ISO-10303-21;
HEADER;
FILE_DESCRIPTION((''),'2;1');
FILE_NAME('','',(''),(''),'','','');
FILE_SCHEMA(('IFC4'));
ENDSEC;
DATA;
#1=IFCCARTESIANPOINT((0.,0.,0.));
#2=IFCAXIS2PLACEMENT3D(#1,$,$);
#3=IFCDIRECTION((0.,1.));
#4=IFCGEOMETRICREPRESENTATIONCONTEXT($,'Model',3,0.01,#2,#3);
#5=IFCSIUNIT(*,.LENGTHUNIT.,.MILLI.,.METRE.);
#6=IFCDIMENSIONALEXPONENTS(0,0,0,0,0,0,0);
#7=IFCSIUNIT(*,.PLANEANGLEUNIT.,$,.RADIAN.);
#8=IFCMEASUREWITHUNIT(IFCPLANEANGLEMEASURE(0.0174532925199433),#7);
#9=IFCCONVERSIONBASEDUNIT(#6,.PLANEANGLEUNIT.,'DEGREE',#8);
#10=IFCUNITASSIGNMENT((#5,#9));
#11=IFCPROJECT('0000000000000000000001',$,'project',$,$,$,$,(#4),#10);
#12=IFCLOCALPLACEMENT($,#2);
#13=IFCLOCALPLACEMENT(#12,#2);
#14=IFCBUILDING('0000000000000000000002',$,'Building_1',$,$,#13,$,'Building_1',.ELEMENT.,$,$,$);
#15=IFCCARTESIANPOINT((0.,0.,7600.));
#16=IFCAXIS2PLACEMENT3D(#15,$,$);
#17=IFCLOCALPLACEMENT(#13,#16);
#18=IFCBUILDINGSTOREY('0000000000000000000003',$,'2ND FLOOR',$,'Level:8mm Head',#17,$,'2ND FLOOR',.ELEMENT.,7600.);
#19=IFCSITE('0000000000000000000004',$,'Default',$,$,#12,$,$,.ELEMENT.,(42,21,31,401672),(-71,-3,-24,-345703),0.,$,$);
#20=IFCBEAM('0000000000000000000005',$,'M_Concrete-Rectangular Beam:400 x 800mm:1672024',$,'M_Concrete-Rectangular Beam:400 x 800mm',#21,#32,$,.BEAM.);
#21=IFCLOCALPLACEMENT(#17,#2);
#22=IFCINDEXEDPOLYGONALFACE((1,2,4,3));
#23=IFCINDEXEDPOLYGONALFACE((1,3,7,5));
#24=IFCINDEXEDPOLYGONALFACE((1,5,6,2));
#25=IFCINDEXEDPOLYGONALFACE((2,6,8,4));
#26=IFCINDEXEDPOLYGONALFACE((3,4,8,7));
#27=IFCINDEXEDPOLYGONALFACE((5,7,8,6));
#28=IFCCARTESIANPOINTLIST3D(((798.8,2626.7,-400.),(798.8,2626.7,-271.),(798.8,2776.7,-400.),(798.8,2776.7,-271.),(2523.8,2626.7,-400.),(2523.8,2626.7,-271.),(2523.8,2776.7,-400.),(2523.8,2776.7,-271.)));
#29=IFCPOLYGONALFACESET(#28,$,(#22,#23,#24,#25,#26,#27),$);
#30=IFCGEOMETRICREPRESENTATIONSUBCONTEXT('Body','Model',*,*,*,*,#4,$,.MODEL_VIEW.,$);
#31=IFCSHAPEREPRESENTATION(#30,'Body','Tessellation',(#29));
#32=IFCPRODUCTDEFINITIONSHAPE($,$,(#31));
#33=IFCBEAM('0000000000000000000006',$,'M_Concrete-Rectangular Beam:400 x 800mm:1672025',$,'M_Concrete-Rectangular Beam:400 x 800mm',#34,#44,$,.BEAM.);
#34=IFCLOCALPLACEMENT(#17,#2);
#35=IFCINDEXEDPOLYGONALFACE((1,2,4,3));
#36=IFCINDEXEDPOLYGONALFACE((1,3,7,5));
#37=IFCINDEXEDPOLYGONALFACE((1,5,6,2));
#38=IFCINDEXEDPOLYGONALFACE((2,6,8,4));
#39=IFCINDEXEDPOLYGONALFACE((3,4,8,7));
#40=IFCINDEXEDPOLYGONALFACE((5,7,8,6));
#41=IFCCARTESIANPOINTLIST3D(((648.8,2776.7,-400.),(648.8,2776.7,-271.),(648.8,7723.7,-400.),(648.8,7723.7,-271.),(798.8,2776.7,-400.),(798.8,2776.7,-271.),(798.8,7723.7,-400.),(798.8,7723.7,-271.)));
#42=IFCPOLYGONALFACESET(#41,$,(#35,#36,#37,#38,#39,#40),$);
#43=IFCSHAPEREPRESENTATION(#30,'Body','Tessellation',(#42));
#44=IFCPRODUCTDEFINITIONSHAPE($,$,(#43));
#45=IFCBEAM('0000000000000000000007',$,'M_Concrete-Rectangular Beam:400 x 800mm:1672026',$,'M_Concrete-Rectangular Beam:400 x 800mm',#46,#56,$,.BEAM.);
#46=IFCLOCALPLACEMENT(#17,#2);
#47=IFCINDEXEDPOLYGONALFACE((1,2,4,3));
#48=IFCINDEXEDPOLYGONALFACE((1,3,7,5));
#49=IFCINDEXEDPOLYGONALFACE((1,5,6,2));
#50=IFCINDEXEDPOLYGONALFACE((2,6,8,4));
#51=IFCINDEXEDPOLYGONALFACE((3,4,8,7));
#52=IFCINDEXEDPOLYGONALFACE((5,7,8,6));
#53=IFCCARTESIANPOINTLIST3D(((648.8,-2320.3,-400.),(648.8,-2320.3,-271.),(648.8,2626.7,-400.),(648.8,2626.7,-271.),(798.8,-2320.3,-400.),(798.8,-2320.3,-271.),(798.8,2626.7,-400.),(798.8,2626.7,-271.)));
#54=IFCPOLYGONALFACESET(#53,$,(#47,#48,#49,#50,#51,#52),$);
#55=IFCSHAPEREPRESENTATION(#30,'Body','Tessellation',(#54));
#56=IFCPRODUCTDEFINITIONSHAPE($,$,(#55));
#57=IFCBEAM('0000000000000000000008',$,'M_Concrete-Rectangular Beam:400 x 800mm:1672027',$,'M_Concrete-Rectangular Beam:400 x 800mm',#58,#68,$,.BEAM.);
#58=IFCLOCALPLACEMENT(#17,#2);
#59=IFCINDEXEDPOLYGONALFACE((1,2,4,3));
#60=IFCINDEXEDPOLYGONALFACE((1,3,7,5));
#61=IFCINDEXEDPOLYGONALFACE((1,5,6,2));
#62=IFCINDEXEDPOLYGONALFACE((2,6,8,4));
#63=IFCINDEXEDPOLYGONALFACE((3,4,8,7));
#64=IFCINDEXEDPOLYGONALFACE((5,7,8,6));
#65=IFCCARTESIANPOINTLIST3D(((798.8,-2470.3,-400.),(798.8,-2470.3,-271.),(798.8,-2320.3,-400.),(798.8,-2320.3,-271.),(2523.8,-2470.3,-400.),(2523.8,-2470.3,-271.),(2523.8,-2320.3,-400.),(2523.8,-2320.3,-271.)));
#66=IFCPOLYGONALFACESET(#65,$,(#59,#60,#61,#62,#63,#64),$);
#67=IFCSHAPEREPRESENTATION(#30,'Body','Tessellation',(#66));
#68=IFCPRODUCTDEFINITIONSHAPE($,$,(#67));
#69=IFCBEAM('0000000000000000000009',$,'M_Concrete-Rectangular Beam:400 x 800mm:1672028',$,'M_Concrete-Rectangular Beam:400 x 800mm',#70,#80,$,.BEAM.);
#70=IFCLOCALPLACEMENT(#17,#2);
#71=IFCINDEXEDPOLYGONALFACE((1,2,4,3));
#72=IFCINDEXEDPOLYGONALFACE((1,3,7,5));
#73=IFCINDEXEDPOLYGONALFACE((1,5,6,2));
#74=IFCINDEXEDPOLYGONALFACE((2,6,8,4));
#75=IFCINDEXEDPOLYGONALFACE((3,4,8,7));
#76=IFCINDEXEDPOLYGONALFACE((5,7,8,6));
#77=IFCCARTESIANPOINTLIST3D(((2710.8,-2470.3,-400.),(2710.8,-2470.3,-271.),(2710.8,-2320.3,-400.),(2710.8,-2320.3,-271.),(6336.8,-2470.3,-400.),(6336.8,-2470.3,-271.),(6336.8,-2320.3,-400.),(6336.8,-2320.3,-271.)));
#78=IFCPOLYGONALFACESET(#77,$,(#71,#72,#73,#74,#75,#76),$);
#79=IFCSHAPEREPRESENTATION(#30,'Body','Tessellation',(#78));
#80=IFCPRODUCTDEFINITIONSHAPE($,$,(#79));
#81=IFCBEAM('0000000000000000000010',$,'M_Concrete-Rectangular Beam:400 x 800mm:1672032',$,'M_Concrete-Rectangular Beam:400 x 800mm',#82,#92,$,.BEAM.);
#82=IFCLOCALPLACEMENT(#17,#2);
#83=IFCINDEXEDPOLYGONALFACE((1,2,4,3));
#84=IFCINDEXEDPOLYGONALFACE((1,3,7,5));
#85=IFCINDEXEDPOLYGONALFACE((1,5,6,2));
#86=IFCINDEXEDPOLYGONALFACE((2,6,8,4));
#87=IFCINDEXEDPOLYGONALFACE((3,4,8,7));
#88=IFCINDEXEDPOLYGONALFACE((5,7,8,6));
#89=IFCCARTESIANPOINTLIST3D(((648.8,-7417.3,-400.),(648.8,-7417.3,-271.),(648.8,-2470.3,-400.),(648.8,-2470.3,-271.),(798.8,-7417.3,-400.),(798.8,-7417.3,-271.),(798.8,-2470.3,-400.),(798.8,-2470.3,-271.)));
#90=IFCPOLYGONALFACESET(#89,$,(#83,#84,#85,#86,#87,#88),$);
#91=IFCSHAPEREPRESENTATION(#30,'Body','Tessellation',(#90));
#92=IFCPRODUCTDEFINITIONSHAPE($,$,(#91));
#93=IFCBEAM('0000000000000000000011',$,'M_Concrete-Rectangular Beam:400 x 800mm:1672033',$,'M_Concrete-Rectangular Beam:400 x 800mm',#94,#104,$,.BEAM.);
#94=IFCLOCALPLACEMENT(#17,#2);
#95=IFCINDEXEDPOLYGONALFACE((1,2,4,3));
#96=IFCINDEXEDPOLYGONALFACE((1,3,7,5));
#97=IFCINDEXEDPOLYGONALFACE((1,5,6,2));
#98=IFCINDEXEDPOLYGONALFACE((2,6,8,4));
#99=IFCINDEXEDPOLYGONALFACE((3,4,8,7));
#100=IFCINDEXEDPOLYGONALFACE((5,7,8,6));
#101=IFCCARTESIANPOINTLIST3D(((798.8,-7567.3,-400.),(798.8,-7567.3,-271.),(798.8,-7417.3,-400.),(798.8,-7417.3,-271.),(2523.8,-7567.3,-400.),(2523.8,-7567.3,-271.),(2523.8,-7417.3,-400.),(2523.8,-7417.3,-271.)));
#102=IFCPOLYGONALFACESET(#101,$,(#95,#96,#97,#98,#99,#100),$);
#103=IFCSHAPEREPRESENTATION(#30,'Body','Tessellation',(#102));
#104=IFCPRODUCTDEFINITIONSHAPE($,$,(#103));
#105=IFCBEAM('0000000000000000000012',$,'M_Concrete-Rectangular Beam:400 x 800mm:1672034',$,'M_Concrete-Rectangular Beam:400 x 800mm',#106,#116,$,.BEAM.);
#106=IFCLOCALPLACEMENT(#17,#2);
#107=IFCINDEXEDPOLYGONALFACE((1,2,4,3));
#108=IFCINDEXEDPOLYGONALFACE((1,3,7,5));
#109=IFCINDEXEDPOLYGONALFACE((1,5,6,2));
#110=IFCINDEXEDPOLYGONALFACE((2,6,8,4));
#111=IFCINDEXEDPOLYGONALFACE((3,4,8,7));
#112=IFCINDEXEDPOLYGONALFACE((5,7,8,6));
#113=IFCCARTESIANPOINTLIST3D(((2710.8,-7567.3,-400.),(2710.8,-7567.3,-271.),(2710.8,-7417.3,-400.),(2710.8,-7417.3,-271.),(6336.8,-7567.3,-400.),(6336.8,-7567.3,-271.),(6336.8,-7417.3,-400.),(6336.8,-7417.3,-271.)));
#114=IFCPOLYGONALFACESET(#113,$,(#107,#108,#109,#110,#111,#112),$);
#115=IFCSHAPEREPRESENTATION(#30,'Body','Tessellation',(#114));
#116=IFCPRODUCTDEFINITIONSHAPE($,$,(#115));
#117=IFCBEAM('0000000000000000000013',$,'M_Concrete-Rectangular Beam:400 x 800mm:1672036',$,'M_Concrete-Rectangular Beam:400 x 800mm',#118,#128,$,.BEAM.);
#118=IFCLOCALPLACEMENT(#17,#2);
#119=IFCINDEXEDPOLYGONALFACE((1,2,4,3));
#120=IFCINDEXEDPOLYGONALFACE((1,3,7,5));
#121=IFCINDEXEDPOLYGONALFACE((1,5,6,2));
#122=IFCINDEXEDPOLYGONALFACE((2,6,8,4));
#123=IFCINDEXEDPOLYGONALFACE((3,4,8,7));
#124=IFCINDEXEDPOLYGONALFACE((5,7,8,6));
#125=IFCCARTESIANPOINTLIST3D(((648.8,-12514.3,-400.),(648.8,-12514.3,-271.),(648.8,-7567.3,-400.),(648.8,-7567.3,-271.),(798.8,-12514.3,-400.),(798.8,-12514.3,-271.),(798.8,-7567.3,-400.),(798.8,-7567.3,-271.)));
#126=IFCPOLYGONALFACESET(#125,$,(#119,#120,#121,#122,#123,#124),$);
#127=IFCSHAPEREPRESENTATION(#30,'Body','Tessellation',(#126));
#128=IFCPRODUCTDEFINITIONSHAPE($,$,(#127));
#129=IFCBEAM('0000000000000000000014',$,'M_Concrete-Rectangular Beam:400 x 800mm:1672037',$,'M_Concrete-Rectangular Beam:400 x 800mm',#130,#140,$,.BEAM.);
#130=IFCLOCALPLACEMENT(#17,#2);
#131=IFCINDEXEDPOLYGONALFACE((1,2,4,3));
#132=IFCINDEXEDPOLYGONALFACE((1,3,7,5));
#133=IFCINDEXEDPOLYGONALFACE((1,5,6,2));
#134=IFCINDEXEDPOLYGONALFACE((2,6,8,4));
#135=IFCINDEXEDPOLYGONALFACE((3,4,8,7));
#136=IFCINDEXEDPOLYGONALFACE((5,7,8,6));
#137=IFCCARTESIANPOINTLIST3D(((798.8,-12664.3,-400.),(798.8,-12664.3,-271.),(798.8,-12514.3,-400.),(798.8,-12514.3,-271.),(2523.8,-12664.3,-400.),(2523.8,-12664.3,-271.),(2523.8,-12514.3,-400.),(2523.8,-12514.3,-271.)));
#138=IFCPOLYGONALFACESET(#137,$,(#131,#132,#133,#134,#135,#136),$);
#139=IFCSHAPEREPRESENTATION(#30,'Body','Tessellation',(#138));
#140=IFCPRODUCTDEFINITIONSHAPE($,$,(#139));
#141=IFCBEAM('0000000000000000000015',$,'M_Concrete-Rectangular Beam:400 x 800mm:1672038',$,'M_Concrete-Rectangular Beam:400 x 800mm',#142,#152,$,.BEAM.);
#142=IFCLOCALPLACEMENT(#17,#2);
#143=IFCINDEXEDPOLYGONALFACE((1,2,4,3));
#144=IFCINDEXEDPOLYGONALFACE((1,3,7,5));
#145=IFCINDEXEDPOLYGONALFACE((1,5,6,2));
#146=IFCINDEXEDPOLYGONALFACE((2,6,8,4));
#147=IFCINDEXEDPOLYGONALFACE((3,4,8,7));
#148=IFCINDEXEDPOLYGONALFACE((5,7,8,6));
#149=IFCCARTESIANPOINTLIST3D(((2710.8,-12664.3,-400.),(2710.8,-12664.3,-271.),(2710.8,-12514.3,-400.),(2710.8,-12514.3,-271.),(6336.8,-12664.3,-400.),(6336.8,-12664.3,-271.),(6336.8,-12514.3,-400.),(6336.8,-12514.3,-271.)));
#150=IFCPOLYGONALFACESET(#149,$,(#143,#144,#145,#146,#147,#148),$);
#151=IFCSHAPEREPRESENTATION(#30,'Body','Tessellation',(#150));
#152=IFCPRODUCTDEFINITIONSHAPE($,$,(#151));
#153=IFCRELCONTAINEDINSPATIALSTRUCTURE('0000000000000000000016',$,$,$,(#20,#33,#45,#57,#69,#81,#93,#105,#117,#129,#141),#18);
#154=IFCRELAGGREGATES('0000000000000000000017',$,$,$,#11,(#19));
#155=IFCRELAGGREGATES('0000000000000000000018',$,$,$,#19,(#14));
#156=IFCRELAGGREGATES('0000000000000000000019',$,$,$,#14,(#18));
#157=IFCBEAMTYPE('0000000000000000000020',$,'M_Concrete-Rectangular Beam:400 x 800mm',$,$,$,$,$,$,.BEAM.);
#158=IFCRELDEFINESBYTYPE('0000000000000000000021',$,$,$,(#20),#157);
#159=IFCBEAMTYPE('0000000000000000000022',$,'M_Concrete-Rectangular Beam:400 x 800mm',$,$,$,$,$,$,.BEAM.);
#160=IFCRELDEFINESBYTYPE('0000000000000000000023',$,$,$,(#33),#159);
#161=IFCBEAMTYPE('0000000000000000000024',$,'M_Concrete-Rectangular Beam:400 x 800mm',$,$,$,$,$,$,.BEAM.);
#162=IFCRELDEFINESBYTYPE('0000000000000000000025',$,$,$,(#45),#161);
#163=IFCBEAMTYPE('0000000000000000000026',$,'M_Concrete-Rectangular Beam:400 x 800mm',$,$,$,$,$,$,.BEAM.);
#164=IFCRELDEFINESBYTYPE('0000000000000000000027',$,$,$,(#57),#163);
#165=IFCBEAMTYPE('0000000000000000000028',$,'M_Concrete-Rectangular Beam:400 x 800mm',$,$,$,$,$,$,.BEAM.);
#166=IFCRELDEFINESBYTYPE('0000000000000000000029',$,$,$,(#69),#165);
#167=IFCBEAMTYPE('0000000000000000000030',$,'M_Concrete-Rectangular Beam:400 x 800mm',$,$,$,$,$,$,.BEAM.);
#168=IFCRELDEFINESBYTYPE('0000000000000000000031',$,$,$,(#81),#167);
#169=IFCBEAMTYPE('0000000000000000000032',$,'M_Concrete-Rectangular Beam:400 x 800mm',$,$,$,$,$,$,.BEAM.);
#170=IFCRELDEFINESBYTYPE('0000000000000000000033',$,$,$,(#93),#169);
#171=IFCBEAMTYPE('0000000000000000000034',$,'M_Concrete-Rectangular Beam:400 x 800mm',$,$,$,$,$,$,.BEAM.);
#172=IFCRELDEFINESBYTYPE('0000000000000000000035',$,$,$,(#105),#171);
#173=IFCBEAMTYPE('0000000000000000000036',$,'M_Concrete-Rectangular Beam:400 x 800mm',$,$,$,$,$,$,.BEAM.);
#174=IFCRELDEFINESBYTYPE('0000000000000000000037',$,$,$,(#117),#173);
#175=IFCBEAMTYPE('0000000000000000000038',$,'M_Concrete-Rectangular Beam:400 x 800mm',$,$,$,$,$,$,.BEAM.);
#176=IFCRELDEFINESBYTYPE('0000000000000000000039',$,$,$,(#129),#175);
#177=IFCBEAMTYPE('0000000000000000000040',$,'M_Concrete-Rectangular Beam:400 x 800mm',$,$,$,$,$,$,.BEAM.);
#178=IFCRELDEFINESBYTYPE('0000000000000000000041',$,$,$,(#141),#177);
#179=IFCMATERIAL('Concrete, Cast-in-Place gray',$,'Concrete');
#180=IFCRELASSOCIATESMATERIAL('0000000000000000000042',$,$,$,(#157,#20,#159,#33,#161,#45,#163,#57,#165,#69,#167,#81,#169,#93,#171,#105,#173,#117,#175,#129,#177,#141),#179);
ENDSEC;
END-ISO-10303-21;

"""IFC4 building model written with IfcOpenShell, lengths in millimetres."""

from ifc_helpers import new_model, entity, si_unit, converted_unit, direction, frame, origin, place, context, subcontext, project, spatial, indexed_curve, outline, extrude, source, transform, mapped, material, type_object, type_shapes, element, save


model = new_model("IFC4")

# Units and contexts
model_context = context("Model", 3, precision=0.01, world=origin(), true_north=direction((0.0, 1.0)))
body_context = subcontext(model_context, "Body", "Model", "MODEL_VIEW")
ifc_project = project(units=[si_unit("LENGTHUNIT", "METRE", prefix="MILLI"), converted_unit("PLANEANGLEUNIT", "DEGREE", entity("IfcPlaneAngleMeasure", 0.0174532925199433), si_unit("PLANEANGLEUNIT", "RADIAN"), dimensions=[0, 0, 0, 0, 0, 0, 0])], contexts=[model_context])

# Site, building, storey
site_placement = place(None, origin())
site = spatial("IfcSite", under=ifc_project, at=site_placement, Name="Default", CompositionType="ELEMENT", RefLatitude=(42, 21, 31, 401672), RefLongitude=(-71, -3, -24, -345703), RefElevation=0.0)
building_placement = place(site_placement, origin())
building = spatial("IfcBuilding", under=site, at=building_placement, Name="Building_1", LongName="Building_1", CompositionType="ELEMENT")
storey_placement = place(building_placement, frame((0.0, 0.0, 7600.0)))
storey = spatial("IfcBuildingStorey", under=building, at=storey_placement, Name="2ND FLOOR", ObjectType="Level:8mm Head", LongName="2ND FLOOR", CompositionType="ELEMENT", Elevation=7600.0)

# Shared definitions
ifc_material_1 = material(Name="Concrete, Cast-in-Place gray", Category="Concrete")

# Beams
beam_type_1 = type_object("IfcBeamType", Name="M_Concrete-Rectangular Beam:400 x 800mm", PredefinedType="BEAM", material=ifc_material_1)
shared_shape_1 = source(origin(), body_context, "Body", "SweptSolid", [
    extrude(outline(indexed_curve([(-64.5, -75.0), (64.5, -75.0), (64.5, 75.0), (-64.5, 75.0), (-64.5, -75.0)], self_intersect=False)), frame((2523.8, 2701.7, 7264.5), z_axis=(-1.0, 0.0, 0.0), x_axis=(0.0, 0.0, -1.0)), (0.0, 0.0, 1.0), 1725.0),
])
type_shapes(beam_type_1, [shared_shape_1])
beam_1_placement = place(storey_placement, frame((0.0, 0.0, -7600.0)))
element("IfcBeam", 1, at=beam_1_placement, inside=storey, type_object=beam_type_1, material=ifc_material_1, Name="M_Concrete-Rectangular Beam:400 x 800mm:1672024", ObjectType="M_Concrete-Rectangular Beam:400 x 800mm", PredefinedType="BEAM", context=body_context, shape_type="MappedRepresentation", body=[
    mapped(shared_shape_1, transform((0.0, 0.0, 0.0), scale=1.0)),
])
beam_type_2 = type_object("IfcBeamType", Name="M_Concrete-Rectangular Beam:400 x 800mm", PredefinedType="BEAM", material=ifc_material_1)
shared_shape_2 = source(origin(), body_context, "Body", "SweptSolid", [
    extrude(outline(indexed_curve([(-75.0, -64.5), (75.0, -64.5), (75.0, 64.5), (-75.0, 64.5), (-75.0, -64.5)], self_intersect=False)), frame((723.8, 2776.7, 7264.5), z_axis=(0.0, 1.0, 0.0), x_axis=(-1.0, 0.0, 0.0)), (0.0, 0.0, 1.0), 4947.0),
])
type_shapes(beam_type_2, [shared_shape_2])
beam_2_placement = place(storey_placement, frame((0.0, 0.0, -7600.0)))
element("IfcBeam", 2, at=beam_2_placement, inside=storey, type_object=beam_type_2, material=ifc_material_1, Name="M_Concrete-Rectangular Beam:400 x 800mm:1672025", ObjectType="M_Concrete-Rectangular Beam:400 x 800mm", PredefinedType="BEAM", context=body_context, shape_type="MappedRepresentation", body=[
    mapped(shared_shape_2, transform((0.0, 0.0, 0.0), scale=1.0)),
])
beam_type_3 = type_object("IfcBeamType", Name="M_Concrete-Rectangular Beam:400 x 800mm", PredefinedType="BEAM", material=ifc_material_1)
shared_shape_3 = source(origin(), body_context, "Body", "SweptSolid", [
    extrude(outline(indexed_curve([(-75.0, -64.5), (75.0, -64.5), (75.0, 64.5), (-75.0, 64.5), (-75.0, -64.5)], self_intersect=False)), frame((723.8, 2626.7, 7264.5), z_axis=(0.0, -1.0, 0.0), x_axis=(-1.0, 0.0, 0.0)), (0.0, 0.0, 1.0), 4947.0),
])
type_shapes(beam_type_3, [shared_shape_3])
beam_3_placement = place(storey_placement, frame((0.0, 0.0, -7600.0)))
element("IfcBeam", 3, at=beam_3_placement, inside=storey, type_object=beam_type_3, material=ifc_material_1, Name="M_Concrete-Rectangular Beam:400 x 800mm:1672026", ObjectType="M_Concrete-Rectangular Beam:400 x 800mm", PredefinedType="BEAM", context=body_context, shape_type="MappedRepresentation", body=[
    mapped(shared_shape_3, transform((0.0, 0.0, 0.0), scale=1.0)),
])
beam_type_4 = type_object("IfcBeamType", Name="M_Concrete-Rectangular Beam:400 x 800mm", PredefinedType="BEAM", material=ifc_material_1)
shared_shape_4 = source(origin(), body_context, "Body", "SweptSolid", [
    extrude(outline(indexed_curve([(-64.5, -75.0), (64.5, -75.0), (64.5, 75.0), (-64.5, 75.0), (-64.5, -75.0)], self_intersect=False)), frame((798.8, -2395.3, 7264.5), z_axis=(1.0, 0.0, 0.0), x_axis=(0.0, 0.0, -1.0)), (0.0, 0.0, 1.0), 1725.0),
])
type_shapes(beam_type_4, [shared_shape_4])
beam_4_placement = place(storey_placement, frame((0.0, 0.0, -7600.0)))
element("IfcBeam", 4, at=beam_4_placement, inside=storey, type_object=beam_type_4, material=ifc_material_1, Name="M_Concrete-Rectangular Beam:400 x 800mm:1672027", ObjectType="M_Concrete-Rectangular Beam:400 x 800mm", PredefinedType="BEAM", context=body_context, shape_type="MappedRepresentation", body=[
    mapped(shared_shape_4, transform((0.0, 0.0, 0.0), scale=1.0)),
])
beam_type_5 = type_object("IfcBeamType", Name="M_Concrete-Rectangular Beam:400 x 800mm", PredefinedType="BEAM", material=ifc_material_1)
shared_shape_5 = source(origin(), body_context, "Body", "SweptSolid", [
    extrude(outline(indexed_curve([(-64.5, -75.0), (64.5, -75.0), (64.5, 75.0), (-64.5, 75.0), (-64.5, -75.0)], self_intersect=False)), frame((2710.8, -2395.3, 7264.5), z_axis=(1.0, 0.0, 0.0), x_axis=(0.0, 0.0, -1.0)), (0.0, 0.0, 1.0), 3626.0),
])
type_shapes(beam_type_5, [shared_shape_5])
beam_5_placement = place(storey_placement, frame((0.0, 0.0, -7600.0)))
element("IfcBeam", 5, at=beam_5_placement, inside=storey, type_object=beam_type_5, material=ifc_material_1, Name="M_Concrete-Rectangular Beam:400 x 800mm:1672028", ObjectType="M_Concrete-Rectangular Beam:400 x 800mm", PredefinedType="BEAM", context=body_context, shape_type="MappedRepresentation", body=[
    mapped(shared_shape_5, transform((0.0, 0.0, 0.0), scale=1.0)),
])
beam_type_6 = type_object("IfcBeamType", Name="M_Concrete-Rectangular Beam:400 x 800mm", PredefinedType="BEAM", material=ifc_material_1)
shared_shape_6 = source(origin(), body_context, "Body", "SweptSolid", [
    extrude(outline(indexed_curve([(-75.0, -64.5), (75.0, -64.5), (75.0, 64.5), (-75.0, 64.5), (-75.0, -64.5)], self_intersect=False)), frame((723.8, -2470.3, 7264.5), z_axis=(0.0, -1.0, 0.0), x_axis=(-1.0, 0.0, 0.0)), (0.0, 0.0, 1.0), 4947.0),
])
type_shapes(beam_type_6, [shared_shape_6])
beam_6_placement = place(storey_placement, frame((0.0, 0.0, -7600.0)))
element("IfcBeam", 6, at=beam_6_placement, inside=storey, type_object=beam_type_6, material=ifc_material_1, Name="M_Concrete-Rectangular Beam:400 x 800mm:1672032", ObjectType="M_Concrete-Rectangular Beam:400 x 800mm", PredefinedType="BEAM", context=body_context, shape_type="MappedRepresentation", body=[
    mapped(shared_shape_6, transform((0.0, 0.0, 0.0), scale=1.0)),
])
beam_type_7 = type_object("IfcBeamType", Name="M_Concrete-Rectangular Beam:400 x 800mm", PredefinedType="BEAM", material=ifc_material_1)
shared_shape_7 = source(origin(), body_context, "Body", "SweptSolid", [
    extrude(outline(indexed_curve([(-64.5, -75.0), (64.5, -75.0), (64.5, 75.0), (-64.5, 75.0), (-64.5, -75.0)], self_intersect=False)), frame((798.8, -7492.3, 7264.5), z_axis=(1.0, 0.0, 0.0), x_axis=(0.0, 0.0, -1.0)), (0.0, 0.0, 1.0), 1725.0),
])
type_shapes(beam_type_7, [shared_shape_7])
beam_7_placement = place(storey_placement, frame((0.0, 0.0, -7600.0)))
element("IfcBeam", 7, at=beam_7_placement, inside=storey, type_object=beam_type_7, material=ifc_material_1, Name="M_Concrete-Rectangular Beam:400 x 800mm:1672033", ObjectType="M_Concrete-Rectangular Beam:400 x 800mm", PredefinedType="BEAM", context=body_context, shape_type="MappedRepresentation", body=[
    mapped(shared_shape_7, transform((0.0, 0.0, 0.0), scale=1.0)),
])
beam_type_8 = type_object("IfcBeamType", Name="M_Concrete-Rectangular Beam:400 x 800mm", PredefinedType="BEAM", material=ifc_material_1)
shared_shape_8 = source(origin(), body_context, "Body", "SweptSolid", [
    extrude(outline(indexed_curve([(-64.5, -75.0), (64.5, -75.0), (64.5, 75.0), (-64.5, 75.0), (-64.5, -75.0)], self_intersect=False)), frame((2710.8, -7492.3, 7264.5), z_axis=(1.0, 0.0, 0.0), x_axis=(0.0, 0.0, -1.0)), (0.0, 0.0, 1.0), 3626.0),
])
type_shapes(beam_type_8, [shared_shape_8])
beam_8_placement = place(storey_placement, frame((0.0, 0.0, -7600.0)))
element("IfcBeam", 8, at=beam_8_placement, inside=storey, type_object=beam_type_8, material=ifc_material_1, Name="M_Concrete-Rectangular Beam:400 x 800mm:1672034", ObjectType="M_Concrete-Rectangular Beam:400 x 800mm", PredefinedType="BEAM", context=body_context, shape_type="MappedRepresentation", body=[
    mapped(shared_shape_8, transform((0.0, 0.0, 0.0), scale=1.0)),
])
beam_type_9 = type_object("IfcBeamType", Name="M_Concrete-Rectangular Beam:400 x 800mm", PredefinedType="BEAM", material=ifc_material_1)
shared_shape_9 = source(origin(), body_context, "Body", "SweptSolid", [
    extrude(outline(indexed_curve([(-75.0, -64.5), (75.0, -64.5), (75.0, 64.5), (-75.0, 64.5), (-75.0, -64.5)], self_intersect=False)), frame((723.8, -7567.3, 7264.5), z_axis=(0.0, -1.0, 0.0), x_axis=(-1.0, 0.0, 0.0)), (0.0, 0.0, 1.0), 4947.0),
])
type_shapes(beam_type_9, [shared_shape_9])
beam_9_placement = place(storey_placement, frame((0.0, 0.0, -7600.0)))
element("IfcBeam", 9, at=beam_9_placement, inside=storey, type_object=beam_type_9, material=ifc_material_1, Name="M_Concrete-Rectangular Beam:400 x 800mm:1672036", ObjectType="M_Concrete-Rectangular Beam:400 x 800mm", PredefinedType="BEAM", context=body_context, shape_type="MappedRepresentation", body=[
    mapped(shared_shape_9, transform((0.0, 0.0, 0.0), scale=1.0)),
])
beam_type_10 = type_object("IfcBeamType", Name="M_Concrete-Rectangular Beam:400 x 800mm", PredefinedType="BEAM", material=ifc_material_1)
shared_shape_10 = source(origin(), body_context, "Body", "SweptSolid", [
    extrude(outline(indexed_curve([(-64.5, -75.0), (64.5, -75.0), (64.5, 75.0), (-64.5, 75.0), (-64.5, -75.0)], self_intersect=False)), frame((798.8, -12589.3, 7264.5), z_axis=(1.0, 0.0, 0.0), x_axis=(0.0, 0.0, -1.0)), (0.0, 0.0, 1.0), 1725.0),
])
type_shapes(beam_type_10, [shared_shape_10])
beam_10_placement = place(storey_placement, frame((0.0, 0.0, -7600.0)))
element("IfcBeam", 10, at=beam_10_placement, inside=storey, type_object=beam_type_10, material=ifc_material_1, Name="M_Concrete-Rectangular Beam:400 x 800mm:1672037", ObjectType="M_Concrete-Rectangular Beam:400 x 800mm", PredefinedType="BEAM", context=body_context, shape_type="MappedRepresentation", body=[
    mapped(shared_shape_10, transform((0.0, 0.0, 0.0), scale=1.0)),
])
beam_type_11 = type_object("IfcBeamType", Name="M_Concrete-Rectangular Beam:400 x 800mm", PredefinedType="BEAM", material=ifc_material_1)
shared_shape_11 = source(origin(), body_context, "Body", "SweptSolid", [
    extrude(outline(indexed_curve([(-64.5, -75.0), (64.5, -75.0), (64.5, 75.0), (-64.5, 75.0), (-64.5, -75.0)], self_intersect=False)), frame((2710.8, -12589.3, 7264.5), z_axis=(1.0, 0.0, 0.0), x_axis=(0.0, 0.0, -1.0)), (0.0, 0.0, 1.0), 3626.0),
])
type_shapes(beam_type_11, [shared_shape_11])
beam_11_placement = place(storey_placement, frame((0.0, 0.0, -7600.0)))
element("IfcBeam", 11, at=beam_11_placement, inside=storey, type_object=beam_type_11, material=ifc_material_1, Name="M_Concrete-Rectangular Beam:400 x 800mm:1672038", ObjectType="M_Concrete-Rectangular Beam:400 x 800mm", PredefinedType="BEAM", context=body_context, shape_type="MappedRepresentation", body=[
    mapped(shared_shape_11, transform((0.0, 0.0, 0.0), scale=1.0)),
])

save(model, "model.ifc")
